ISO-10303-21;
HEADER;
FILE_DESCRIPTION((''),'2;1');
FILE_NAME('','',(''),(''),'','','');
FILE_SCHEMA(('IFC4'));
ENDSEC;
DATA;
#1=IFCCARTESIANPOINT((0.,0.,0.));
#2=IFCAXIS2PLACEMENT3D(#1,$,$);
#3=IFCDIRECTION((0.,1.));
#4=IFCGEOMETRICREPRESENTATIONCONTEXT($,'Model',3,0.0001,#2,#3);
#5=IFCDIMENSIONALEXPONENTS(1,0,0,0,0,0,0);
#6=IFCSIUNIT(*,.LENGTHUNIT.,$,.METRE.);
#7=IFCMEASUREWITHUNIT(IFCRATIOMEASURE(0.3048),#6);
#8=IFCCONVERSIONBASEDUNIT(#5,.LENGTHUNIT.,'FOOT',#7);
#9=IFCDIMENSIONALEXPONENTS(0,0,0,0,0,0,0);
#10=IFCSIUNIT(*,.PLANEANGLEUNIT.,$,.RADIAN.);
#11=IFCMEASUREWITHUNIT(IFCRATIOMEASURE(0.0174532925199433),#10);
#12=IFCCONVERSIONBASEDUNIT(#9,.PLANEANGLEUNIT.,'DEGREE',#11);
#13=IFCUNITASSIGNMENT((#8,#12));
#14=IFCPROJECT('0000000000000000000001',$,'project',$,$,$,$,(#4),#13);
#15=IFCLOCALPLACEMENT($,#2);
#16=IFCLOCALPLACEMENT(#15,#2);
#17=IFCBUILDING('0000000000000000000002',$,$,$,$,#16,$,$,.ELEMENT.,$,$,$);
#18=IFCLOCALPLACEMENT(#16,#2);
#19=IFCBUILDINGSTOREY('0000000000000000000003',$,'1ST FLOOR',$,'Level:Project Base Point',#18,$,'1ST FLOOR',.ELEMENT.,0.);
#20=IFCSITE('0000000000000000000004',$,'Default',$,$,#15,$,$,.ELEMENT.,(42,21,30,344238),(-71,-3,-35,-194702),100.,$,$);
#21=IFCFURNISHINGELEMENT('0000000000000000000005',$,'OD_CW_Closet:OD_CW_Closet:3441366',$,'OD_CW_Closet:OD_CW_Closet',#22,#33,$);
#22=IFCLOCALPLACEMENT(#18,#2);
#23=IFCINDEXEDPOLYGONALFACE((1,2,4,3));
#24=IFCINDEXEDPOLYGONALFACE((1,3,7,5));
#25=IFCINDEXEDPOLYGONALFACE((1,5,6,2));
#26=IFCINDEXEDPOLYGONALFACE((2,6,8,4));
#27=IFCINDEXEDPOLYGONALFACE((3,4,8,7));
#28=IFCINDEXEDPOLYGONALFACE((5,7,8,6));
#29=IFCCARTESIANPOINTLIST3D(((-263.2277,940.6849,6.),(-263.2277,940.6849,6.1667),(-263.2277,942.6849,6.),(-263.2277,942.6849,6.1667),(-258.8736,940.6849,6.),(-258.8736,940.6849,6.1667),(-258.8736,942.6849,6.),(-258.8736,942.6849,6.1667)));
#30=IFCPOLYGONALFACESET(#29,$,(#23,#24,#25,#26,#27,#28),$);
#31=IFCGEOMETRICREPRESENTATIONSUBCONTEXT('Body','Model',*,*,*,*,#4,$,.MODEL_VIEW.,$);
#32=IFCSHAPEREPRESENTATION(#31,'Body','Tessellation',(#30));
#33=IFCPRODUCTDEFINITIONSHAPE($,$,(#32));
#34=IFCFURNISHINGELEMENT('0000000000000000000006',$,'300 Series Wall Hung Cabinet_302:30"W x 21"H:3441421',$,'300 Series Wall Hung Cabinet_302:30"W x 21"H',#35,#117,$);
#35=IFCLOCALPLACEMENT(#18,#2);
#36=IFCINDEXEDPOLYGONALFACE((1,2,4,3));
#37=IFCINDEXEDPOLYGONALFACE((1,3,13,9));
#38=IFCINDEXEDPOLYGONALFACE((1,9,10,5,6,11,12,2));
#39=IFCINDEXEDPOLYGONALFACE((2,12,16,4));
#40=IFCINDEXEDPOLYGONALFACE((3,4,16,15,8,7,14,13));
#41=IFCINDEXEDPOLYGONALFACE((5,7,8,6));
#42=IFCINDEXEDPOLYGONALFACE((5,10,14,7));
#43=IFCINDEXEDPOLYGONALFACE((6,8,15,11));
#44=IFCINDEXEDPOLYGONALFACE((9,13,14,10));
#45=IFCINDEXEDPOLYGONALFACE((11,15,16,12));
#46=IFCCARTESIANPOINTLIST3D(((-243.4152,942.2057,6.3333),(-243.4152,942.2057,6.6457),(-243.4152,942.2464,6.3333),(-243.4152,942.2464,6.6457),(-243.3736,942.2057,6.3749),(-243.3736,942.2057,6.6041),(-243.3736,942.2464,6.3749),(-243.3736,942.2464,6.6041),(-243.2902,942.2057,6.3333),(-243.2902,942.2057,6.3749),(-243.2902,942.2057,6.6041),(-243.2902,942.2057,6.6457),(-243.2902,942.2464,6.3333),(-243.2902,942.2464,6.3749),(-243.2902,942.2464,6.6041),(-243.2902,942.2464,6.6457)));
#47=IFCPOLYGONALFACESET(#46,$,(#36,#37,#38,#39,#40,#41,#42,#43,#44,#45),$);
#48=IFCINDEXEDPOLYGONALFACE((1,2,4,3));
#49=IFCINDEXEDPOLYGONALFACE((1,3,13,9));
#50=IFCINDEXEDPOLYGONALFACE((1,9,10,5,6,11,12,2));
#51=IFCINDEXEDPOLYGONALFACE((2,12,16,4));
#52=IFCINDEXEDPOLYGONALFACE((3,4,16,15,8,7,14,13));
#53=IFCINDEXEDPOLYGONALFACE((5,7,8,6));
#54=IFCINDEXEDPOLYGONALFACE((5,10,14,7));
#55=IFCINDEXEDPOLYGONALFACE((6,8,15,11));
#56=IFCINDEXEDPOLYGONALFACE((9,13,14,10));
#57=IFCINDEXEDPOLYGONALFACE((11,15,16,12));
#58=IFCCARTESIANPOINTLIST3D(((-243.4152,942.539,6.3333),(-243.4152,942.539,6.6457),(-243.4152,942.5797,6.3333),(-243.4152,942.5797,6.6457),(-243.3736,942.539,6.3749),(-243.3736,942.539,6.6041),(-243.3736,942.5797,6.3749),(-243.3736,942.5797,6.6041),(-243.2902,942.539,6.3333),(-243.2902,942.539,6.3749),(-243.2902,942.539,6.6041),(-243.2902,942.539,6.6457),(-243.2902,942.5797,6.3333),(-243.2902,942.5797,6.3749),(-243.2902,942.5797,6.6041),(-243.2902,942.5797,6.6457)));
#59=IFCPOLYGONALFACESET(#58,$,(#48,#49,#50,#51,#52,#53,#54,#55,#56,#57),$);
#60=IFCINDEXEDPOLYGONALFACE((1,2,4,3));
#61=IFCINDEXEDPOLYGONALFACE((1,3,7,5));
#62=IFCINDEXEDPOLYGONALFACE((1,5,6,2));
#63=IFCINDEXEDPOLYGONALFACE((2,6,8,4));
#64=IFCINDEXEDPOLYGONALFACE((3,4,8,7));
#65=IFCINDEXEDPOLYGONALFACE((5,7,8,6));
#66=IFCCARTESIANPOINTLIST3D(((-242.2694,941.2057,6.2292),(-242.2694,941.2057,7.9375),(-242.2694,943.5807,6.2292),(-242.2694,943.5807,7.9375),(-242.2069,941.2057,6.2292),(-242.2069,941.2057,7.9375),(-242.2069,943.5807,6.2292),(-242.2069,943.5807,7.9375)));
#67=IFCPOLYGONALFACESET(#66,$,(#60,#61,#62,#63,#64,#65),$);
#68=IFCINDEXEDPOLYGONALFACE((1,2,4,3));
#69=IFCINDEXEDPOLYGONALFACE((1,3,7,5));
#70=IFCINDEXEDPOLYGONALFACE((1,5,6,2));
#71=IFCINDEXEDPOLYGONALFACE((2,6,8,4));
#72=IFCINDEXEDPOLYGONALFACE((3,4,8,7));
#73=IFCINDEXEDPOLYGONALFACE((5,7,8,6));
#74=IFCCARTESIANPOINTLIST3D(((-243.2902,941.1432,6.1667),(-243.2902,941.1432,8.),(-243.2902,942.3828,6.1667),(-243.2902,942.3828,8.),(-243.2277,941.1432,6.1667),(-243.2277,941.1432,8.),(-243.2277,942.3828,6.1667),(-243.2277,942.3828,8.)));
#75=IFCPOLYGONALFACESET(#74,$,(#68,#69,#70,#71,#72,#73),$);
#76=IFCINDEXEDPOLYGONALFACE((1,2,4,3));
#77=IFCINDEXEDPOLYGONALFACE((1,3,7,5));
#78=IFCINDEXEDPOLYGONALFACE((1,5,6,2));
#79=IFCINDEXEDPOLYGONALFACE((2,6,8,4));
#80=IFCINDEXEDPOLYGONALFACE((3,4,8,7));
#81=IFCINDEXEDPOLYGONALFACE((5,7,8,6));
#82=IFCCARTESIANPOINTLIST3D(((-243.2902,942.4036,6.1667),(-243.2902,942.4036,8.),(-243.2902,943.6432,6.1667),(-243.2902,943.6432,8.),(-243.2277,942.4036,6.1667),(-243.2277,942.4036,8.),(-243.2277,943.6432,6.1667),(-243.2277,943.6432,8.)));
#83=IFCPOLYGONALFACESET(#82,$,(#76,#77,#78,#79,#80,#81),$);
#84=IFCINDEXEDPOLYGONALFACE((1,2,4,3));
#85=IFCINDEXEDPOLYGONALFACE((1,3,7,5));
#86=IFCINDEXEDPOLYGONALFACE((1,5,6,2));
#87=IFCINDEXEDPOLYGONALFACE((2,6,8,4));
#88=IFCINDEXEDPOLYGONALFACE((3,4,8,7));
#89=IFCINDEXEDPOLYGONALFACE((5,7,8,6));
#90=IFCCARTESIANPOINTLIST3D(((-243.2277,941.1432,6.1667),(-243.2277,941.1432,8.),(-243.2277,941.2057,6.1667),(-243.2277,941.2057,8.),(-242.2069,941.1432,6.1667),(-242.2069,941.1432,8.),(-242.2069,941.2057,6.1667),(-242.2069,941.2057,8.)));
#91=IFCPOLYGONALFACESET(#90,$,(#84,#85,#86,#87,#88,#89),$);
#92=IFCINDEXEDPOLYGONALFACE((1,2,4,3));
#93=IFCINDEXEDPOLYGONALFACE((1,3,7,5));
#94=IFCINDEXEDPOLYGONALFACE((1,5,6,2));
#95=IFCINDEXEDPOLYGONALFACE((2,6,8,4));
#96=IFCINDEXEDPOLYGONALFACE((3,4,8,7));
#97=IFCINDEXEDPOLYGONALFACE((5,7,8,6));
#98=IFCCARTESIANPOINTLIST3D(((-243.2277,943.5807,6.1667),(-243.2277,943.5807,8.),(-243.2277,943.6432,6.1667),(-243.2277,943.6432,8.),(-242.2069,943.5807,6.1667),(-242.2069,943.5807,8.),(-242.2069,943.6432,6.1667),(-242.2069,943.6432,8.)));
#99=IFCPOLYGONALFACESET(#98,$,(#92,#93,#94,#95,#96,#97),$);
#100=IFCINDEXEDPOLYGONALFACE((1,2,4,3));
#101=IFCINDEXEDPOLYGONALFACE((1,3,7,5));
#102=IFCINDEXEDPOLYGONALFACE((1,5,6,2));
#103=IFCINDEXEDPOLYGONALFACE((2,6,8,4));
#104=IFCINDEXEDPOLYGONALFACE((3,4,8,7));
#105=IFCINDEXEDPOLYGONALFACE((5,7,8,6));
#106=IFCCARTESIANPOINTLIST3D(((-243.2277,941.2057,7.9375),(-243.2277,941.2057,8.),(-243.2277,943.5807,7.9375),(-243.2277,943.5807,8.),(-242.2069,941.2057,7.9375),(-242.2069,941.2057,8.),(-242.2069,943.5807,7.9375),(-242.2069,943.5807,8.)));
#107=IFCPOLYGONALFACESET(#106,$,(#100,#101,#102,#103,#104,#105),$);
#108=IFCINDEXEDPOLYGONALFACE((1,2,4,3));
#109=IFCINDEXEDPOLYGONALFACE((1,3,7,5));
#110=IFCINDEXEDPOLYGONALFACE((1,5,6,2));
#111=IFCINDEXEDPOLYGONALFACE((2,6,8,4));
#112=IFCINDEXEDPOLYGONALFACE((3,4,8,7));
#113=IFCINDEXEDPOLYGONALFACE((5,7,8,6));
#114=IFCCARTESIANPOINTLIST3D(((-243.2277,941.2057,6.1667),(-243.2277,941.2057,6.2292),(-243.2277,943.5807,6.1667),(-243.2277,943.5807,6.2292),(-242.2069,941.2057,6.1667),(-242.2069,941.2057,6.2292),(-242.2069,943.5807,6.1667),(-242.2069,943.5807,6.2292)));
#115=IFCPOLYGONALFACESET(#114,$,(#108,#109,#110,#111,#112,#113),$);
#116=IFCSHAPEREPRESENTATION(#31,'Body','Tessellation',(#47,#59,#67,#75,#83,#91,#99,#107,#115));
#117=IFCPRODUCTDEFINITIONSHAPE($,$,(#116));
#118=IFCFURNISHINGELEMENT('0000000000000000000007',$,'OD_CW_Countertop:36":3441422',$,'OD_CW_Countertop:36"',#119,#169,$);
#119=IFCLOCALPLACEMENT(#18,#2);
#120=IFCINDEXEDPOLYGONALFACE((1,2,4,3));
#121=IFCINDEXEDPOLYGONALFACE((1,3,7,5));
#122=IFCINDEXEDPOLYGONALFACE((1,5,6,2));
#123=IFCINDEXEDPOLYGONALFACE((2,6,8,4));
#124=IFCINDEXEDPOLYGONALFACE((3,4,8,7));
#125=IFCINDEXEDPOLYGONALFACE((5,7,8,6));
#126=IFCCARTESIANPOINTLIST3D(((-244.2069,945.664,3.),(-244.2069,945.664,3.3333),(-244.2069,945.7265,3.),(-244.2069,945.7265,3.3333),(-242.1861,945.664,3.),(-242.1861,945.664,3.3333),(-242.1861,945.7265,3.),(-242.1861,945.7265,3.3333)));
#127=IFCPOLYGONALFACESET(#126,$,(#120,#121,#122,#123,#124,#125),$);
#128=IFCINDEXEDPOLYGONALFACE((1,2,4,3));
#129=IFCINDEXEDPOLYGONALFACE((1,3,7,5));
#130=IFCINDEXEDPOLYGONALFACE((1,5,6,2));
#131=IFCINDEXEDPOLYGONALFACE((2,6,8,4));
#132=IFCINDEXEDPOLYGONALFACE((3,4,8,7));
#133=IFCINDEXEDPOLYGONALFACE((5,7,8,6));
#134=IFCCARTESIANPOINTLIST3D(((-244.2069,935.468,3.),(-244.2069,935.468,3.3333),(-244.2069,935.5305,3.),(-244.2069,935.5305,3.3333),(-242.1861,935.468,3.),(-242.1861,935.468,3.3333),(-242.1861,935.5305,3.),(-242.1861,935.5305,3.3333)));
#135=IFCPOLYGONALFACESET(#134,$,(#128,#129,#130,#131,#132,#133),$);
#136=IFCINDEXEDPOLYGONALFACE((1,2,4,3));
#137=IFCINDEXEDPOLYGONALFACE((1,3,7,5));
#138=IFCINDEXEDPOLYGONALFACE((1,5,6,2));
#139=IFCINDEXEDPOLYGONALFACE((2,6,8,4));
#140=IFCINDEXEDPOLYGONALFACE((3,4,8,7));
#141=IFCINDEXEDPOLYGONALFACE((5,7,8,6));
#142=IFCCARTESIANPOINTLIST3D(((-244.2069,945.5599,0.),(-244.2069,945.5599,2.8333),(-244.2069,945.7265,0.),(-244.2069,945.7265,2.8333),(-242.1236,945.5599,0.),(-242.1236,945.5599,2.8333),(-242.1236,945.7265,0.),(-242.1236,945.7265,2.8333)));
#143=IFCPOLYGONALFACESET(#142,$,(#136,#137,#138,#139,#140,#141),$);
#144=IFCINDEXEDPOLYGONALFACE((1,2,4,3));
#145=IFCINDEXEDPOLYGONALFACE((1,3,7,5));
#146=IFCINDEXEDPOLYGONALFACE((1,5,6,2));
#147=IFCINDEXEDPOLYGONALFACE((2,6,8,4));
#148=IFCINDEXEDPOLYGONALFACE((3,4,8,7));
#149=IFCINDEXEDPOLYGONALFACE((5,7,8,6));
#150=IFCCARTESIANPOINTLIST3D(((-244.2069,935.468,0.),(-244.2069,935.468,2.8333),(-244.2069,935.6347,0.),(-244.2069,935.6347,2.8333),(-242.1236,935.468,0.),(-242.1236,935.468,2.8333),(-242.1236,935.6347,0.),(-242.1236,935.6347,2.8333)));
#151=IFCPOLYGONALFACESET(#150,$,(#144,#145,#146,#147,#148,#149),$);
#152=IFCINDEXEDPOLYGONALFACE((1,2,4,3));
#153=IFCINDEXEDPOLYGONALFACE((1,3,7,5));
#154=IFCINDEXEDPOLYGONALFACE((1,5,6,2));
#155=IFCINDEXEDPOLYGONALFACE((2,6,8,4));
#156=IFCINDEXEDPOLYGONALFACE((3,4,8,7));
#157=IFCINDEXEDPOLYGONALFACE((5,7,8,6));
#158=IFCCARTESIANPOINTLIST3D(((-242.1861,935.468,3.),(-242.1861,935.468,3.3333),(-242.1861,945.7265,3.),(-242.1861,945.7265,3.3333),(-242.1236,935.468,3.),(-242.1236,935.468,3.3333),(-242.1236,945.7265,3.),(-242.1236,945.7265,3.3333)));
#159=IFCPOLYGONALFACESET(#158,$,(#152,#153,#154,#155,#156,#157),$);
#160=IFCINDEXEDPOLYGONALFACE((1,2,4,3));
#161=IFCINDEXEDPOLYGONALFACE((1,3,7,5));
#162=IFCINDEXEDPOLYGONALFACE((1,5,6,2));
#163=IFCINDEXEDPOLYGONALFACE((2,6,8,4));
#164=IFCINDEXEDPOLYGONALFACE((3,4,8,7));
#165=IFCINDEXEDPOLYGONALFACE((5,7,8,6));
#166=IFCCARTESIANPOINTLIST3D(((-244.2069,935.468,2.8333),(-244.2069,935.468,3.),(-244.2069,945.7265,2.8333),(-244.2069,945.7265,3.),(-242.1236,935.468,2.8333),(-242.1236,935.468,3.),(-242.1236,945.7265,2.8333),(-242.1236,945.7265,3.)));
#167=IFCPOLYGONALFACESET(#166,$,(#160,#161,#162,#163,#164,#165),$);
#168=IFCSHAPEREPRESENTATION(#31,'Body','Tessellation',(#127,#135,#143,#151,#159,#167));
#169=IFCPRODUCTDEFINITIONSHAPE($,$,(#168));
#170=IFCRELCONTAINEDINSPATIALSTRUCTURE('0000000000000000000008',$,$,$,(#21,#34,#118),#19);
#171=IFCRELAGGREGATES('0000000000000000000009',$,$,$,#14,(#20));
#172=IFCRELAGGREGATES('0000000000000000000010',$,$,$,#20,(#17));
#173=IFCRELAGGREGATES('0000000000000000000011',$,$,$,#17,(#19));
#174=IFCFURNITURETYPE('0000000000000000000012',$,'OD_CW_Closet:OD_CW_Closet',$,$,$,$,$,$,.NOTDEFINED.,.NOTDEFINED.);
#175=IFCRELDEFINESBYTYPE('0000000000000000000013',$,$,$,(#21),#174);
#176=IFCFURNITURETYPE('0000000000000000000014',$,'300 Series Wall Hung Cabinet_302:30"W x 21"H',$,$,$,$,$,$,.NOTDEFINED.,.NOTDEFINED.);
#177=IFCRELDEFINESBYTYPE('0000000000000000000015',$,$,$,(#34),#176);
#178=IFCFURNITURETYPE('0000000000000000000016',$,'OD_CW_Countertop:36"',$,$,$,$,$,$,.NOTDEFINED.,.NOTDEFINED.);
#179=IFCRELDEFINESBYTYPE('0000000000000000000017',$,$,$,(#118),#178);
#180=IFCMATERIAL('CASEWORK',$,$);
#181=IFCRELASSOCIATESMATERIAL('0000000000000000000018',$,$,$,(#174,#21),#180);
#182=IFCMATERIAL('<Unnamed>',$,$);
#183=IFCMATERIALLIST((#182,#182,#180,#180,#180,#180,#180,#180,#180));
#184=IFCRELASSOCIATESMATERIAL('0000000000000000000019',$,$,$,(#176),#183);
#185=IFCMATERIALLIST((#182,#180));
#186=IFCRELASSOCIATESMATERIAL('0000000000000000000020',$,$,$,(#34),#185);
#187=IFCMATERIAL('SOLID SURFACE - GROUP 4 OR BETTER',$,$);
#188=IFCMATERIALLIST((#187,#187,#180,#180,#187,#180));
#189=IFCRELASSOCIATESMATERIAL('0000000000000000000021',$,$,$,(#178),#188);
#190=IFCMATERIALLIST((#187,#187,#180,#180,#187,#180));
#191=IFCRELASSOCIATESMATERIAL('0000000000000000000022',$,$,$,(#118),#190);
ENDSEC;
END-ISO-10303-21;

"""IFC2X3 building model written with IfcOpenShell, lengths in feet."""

from ifc_helpers import new_model, entity, si_unit, converted_unit, direction, frame, frame_2d, origin, origin_2d_with_axis, place, context, subcontext, project, spatial, polyline, rectangle, outline, extrude, source, transform, mapped, material, material_list, type_object, type_shapes, element, save


model = new_model("IFC2X3")

# Units and contexts
model_context = context("Model", 3, precision=0.0001, world=origin(), true_north=direction((0.0, 1.0)))
body_context = subcontext(model_context, "Body", "Model", "MODEL_VIEW")
ifc_project = project(units=[converted_unit("LENGTHUNIT", "FOOT", entity("IfcRatioMeasure", 0.3048), si_unit("LENGTHUNIT", "METRE"), dimensions=[1, 0, 0, 0, 0, 0, 0]), converted_unit("PLANEANGLEUNIT", "DEGREE", entity("IfcRatioMeasure", 0.0174532925199433), si_unit("PLANEANGLEUNIT", "RADIAN"), dimensions=[0, 0, 0, 0, 0, 0, 0])], contexts=[model_context])

# Site, building, storey
site_placement = place(None, origin())
site = spatial("IfcSite", under=ifc_project, at=site_placement, Name="Default", CompositionType="ELEMENT", RefLatitude=(42, 21, 30, 344238), RefLongitude=(-71, -3, -35, -194702), RefElevation=100.0)
building_placement = place(site_placement, origin())
building = spatial("IfcBuilding", under=site, at=building_placement, CompositionType="ELEMENT")
storey_placement = place(building_placement, origin())
storey = spatial("IfcBuildingStorey", under=building, at=storey_placement, Name="1ST FLOOR", ObjectType="Level:Project Base Point", LongName="1ST FLOOR", CompositionType="ELEMENT", Elevation=0.0)

# Furnishing elements
ifc_material_1 = material(Name="CASEWORK")
ifc_material_2 = material(Name="<Unnamed>")
furniture_type_1 = type_object("IfcFurnitureType", Name="OD_CW_Closet:OD_CW_Closet", material=ifc_material_1)
shared_shape_1 = source(origin(), body_context, "Body", "SweptSolid", [
    extrude(rectangle(XDim=2.0, YDim=4.3542, at=frame_2d((0.0, 0.0), x_axis=(1.0, 0.0))), frame((2.1771, 1.0, 0.0), z_axis=(0.0, 0.0, 1.0), x_axis=(0.0, -1.0, 0.0)), (0.0, 0.0, 1.0), 0.1667),
])
type_shapes(furniture_type_1, [shared_shape_1])
furnishing_1_placement = place(storey_placement, frame((-263.2277, 940.6849, 6.0)))
element("IfcFurnishingElement", 1, at=furnishing_1_placement, inside=storey, type_object=furniture_type_1, material=ifc_material_1, Name="OD_CW_Closet:OD_CW_Closet:3441366", ObjectType="OD_CW_Closet:OD_CW_Closet", context=body_context, shape_type="MappedRepresentation", body=[
    mapped(shared_shape_1, transform((0.0, 0.0, 0.0), scale=1.0)),
])
ifc_material_list_1 = material_list([ifc_material_2, ifc_material_1])
ifc_material_list_2 = material_list([ifc_material_2, ifc_material_2, ifc_material_1, ifc_material_1, ifc_material_1, ifc_material_1, ifc_material_1, ifc_material_1, ifc_material_1])
furniture_type_2 = type_object("IfcFurnitureType", Name="300 Series Wall Hung Cabinet_302:30\"W x 21\"H", material=ifc_material_list_2)
shared_shape_2 = source(origin(), body_context, "Body", "SweptSolid", [
    extrude(outline(polyline([(-0.0521, -0.1146), (-0.0521, -0.1562), (0.0729, -0.1562), (0.0729, 0.1562), (-0.0521, 0.1562), (-0.0521, 0.1146), (0.0313, 0.1146), (0.0313, -0.1146), (-0.0521, -0.1146)])), frame((1.0625, 1.1354, 0.3229), z_axis=(-1.0, 0.0, 0.0), x_axis=(0.0, 1.0, 0.0)), (0.0, 0.0, -1.0), 0.0407),
    extrude(outline(polyline([(-0.0521, -0.1146), (-0.0521, -0.1562), (0.0729, -0.1562), (0.0729, 0.1562), (-0.0521, 0.1562), (-0.0521, 0.1146), (0.0313, 0.1146), (0.0313, -0.1146), (-0.0521, -0.1146)])), frame((1.3958, 1.1354, 0.3229), z_axis=(-1.0, 0.0, 0.0), x_axis=(0.0, 1.0, 0.0)), (0.0, 0.0, -1.0), 0.0407),
    extrude(rectangle(XDim=0.0625, YDim=2.375, at=frame_2d((0.0, 0.0), x_axis=(1.0, 0.0))), frame((1.25, 0.0313, 0.0625), z_axis=(0.0, 0.0, 1.0), x_axis=(0.0, 1.0, 0.0)), (0.0, 0.0, 1.0), 1.7083),
    extrude(rectangle(XDim=0.0625, YDim=1.2396, at=origin_2d_with_axis()), frame((0.6198, 1.0521, 0.0), z_axis=(0.0, 0.0, 1.0), x_axis=(0.0, 1.0, 0.0)), (0.0, 0.0, 1.0), 1.8333),
    extrude(rectangle(XDim=0.0625, YDim=1.2396, at=frame_2d((0.0, 0.0), x_axis=(1.0, 0.0))), frame((1.8802, 1.0521, 0.0), z_axis=(0.0, 0.0, 1.0), x_axis=(0.0, 1.0, 0.0)), (0.0, 0.0, 1.0), 1.8333),
    extrude(rectangle(XDim=0.0625, YDim=1.0208, at=frame_2d((0.0, 0.0), x_axis=(1.0, 0.0))), frame((0.0313, 0.5104, 0.0)), (0.0, 0.0, 1.0), 1.8333),
    extrude(rectangle(XDim=0.0625, YDim=1.0208, at=frame_2d((0.0, 0.0), x_axis=(1.0, 0.0))), frame((2.4688, 0.5104, 0.0)), (0.0, 0.0, 1.0), 1.8333),
    extrude(rectangle(XDim=2.375, YDim=1.0208, at=origin_2d_with_axis()), frame((1.25, 0.5104, 1.7708), z_axis=(0.0, 0.0, 1.0), x_axis=(-1.0, 0.0, 0.0)), (0.0, 0.0, 1.0), 0.0625),
    extrude(rectangle(XDim=2.375, YDim=1.0208, at=origin_2d_with_axis()), frame((1.25, 0.5104, 0.0), z_axis=(0.0, 0.0, 1.0), x_axis=(-1.0, 0.0, 0.0)), (0.0, 0.0, 1.0), 0.0625),
])
type_shapes(furniture_type_2, [shared_shape_2])
furnishing_2_placement = place(storey_placement, frame((-242.2069, 941.1432, 6.1667), z_axis=(0.0, 0.0, 1.0), x_axis=(0.0, 1.0, 0.0)))
element("IfcFurnishingElement", 2, at=furnishing_2_placement, inside=storey, type_object=furniture_type_2, material=ifc_material_list_1, Name="300 Series Wall Hung Cabinet_302:30\"W x 21\"H:3441421", ObjectType="300 Series Wall Hung Cabinet_302:30\"W x 21\"H", context=body_context, shape_type="MappedRepresentation", body=[
    mapped(shared_shape_2, transform((0.0, 0.0, 0.0), scale=1.0)),
])
ifc_material_3 = material(Name="SOLID SURFACE - GROUP 4 OR BETTER")
ifc_material_list_3 = material_list([ifc_material_3, ifc_material_3, ifc_material_1, ifc_material_1, ifc_material_3, ifc_material_1])
ifc_material_list_4 = material_list([ifc_material_3, ifc_material_3, ifc_material_1, ifc_material_1, ifc_material_3, ifc_material_1])
furniture_type_3 = type_object("IfcFurnitureType", Name="OD_CW_Countertop:36\"", material=ifc_material_list_4)
shared_shape_3 = source(origin(), body_context, "Body", "SweptSolid", [
    extrude(rectangle(XDim=2.0208, YDim=0.0625, at=origin_2d_with_axis()), frame((10.2272, 1.0729, 3.0), z_axis=(0.0, 0.0, 1.0), x_axis=(0.0, 1.0, 0.0)), (0.0, 0.0, 1.0), 0.3333),
    extrude(rectangle(XDim=2.0208, YDim=0.0625, at=origin_2d_with_axis()), frame((0.0313, 1.0729, 3.0), z_axis=(0.0, 0.0, 1.0), x_axis=(0.0, 1.0, 0.0)), (0.0, 0.0, 1.0), 0.3333),
    extrude(rectangle(XDim=0.1667, YDim=2.0833, at=frame_2d((0.0, 0.0), x_axis=(1.0, 0.0))), frame((10.1751, 1.0417, 0.0)), (0.0, 0.0, 1.0), 2.8333),
    extrude(rectangle(XDim=0.1667, YDim=2.0833, at=frame_2d((0.0, 0.0), x_axis=(1.0, 0.0))), frame((0.0833, 1.0417, 0.0)), (0.0, 0.0, 1.0), 2.8333),
    extrude(rectangle(XDim=10.2585, YDim=0.0625, at=frame_2d((0.0, 0.0), x_axis=(1.0, 0.0))), frame((5.1292, 0.0313, 3.0)), (0.0, 0.0, 1.0), 0.3333),
    extrude(rectangle(XDim=10.2585, YDim=2.0833, at=origin_2d_with_axis()), frame((5.1292, 1.0417, 2.8333)), (0.0, 0.0, 1.0), 0.1667),
])
type_shapes(furniture_type_3, [shared_shape_3])
furnishing_3_placement = place(storey_placement, frame((-242.1236, 935.468, 0.0), z_axis=(0.0, 0.0, 1.0), x_axis=(0.0, 1.0, 0.0)))
element("IfcFurnishingElement", 3, at=furnishing_3_placement, inside=storey, type_object=furniture_type_3, material=ifc_material_list_3, Name="OD_CW_Countertop:36\":3441422", ObjectType="OD_CW_Countertop:36\"", context=body_context, shape_type="MappedRepresentation", body=[
    mapped(shared_shape_3, transform((0.0, 0.0, 0.0), scale=1.0)),
])

save(model, "model.ifc")
